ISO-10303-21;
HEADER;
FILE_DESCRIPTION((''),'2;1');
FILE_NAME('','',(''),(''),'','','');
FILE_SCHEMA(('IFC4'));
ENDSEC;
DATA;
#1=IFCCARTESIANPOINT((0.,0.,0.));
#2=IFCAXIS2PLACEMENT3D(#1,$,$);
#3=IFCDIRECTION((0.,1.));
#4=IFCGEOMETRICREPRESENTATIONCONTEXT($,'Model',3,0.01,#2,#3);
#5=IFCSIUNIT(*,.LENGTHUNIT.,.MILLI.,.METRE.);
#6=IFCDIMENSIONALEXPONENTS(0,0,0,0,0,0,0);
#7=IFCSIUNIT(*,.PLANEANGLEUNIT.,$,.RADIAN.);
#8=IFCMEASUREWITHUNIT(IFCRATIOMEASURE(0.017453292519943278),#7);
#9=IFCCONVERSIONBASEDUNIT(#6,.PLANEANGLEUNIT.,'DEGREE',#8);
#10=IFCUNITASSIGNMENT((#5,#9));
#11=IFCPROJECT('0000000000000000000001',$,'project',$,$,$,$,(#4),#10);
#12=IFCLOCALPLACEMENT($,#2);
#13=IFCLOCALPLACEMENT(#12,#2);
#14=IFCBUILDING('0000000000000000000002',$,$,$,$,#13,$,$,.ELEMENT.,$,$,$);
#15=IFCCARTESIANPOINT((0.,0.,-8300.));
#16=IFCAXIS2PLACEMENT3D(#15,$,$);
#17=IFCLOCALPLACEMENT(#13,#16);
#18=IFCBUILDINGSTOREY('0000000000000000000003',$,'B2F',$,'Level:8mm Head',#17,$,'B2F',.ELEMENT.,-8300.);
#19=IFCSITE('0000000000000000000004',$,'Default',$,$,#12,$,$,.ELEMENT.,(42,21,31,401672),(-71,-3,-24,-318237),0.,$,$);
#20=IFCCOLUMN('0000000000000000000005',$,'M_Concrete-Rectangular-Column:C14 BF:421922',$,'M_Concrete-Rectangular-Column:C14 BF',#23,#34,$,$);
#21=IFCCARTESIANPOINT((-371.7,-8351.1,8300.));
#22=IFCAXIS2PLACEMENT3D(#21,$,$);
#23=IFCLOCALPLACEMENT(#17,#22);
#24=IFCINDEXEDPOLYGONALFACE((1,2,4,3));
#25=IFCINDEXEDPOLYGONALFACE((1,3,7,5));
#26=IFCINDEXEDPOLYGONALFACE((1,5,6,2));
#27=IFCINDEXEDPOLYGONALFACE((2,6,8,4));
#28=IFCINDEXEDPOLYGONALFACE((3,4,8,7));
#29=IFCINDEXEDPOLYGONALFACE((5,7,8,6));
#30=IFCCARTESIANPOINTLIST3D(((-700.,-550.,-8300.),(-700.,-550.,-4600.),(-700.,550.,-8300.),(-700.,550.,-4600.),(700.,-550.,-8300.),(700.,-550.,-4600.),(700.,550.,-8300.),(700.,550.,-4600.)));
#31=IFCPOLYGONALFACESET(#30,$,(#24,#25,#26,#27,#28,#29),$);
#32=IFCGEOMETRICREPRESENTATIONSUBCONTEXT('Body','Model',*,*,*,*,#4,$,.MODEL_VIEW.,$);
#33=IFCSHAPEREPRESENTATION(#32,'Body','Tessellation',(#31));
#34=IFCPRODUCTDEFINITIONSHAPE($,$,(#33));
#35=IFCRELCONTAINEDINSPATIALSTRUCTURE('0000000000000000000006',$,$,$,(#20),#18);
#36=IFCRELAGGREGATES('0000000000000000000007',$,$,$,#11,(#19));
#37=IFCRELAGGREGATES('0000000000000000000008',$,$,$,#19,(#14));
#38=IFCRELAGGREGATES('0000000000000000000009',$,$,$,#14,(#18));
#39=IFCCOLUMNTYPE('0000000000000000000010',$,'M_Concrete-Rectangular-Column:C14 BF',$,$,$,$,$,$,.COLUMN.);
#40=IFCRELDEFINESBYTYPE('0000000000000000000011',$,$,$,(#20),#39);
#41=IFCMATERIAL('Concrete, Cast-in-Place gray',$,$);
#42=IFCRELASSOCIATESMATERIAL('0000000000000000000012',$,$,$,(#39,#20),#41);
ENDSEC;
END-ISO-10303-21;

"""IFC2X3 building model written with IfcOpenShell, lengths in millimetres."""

from ifc_helpers import new_model, entity, si_unit, converted_unit, direction, frame, origin, origin_2d_with_axis, place, context, subcontext, project, spatial, rectangle, extrude, source, transform, mapped, material, type_object, type_shapes, element, save


model = new_model("IFC2X3")

# Units and contexts
model_context = context("Model", 3, precision=0.01, world=origin(), true_north=direction((0.0, 1.0)))
body_context = subcontext(model_context, "Body", "Model", "MODEL_VIEW")
ifc_project = project(units=[si_unit("LENGTHUNIT", "METRE", prefix="MILLI"), converted_unit("PLANEANGLEUNIT", "DEGREE", entity("IfcRatioMeasure", 0.017453292519943278), si_unit("PLANEANGLEUNIT", "RADIAN"), dimensions=[0, 0, 0, 0, 0, 0, 0])], contexts=[model_context])

# Site, building, storey
site_placement = place(None, origin())
site = spatial("IfcSite", under=ifc_project, at=site_placement, Name="Default", CompositionType="ELEMENT", RefLatitude=(42, 21, 31, 401672), RefLongitude=(-71, -3, -24, -318237), RefElevation=0.0)
building_placement = place(site_placement, origin())
building = spatial("IfcBuilding", under=site, at=building_placement, CompositionType="ELEMENT")
storey_placement = place(building_placement, frame((0.0, 0.0, -8300.0)))
storey = spatial("IfcBuildingStorey", under=building, at=storey_placement, Name="B2F", ObjectType="Level:8mm Head", LongName="B2F", CompositionType="ELEMENT", Elevation=-8300.0)

# Column
ifc_material_1 = material(Name="Concrete, Cast-in-Place gray")
column_type = type_object("IfcColumnType", Name="M_Concrete-Rectangular-Column:C14 BF", PredefinedType="COLUMN", material=ifc_material_1)
shared_shape = source(origin(), body_context, "Body", "SweptSolid", [
    extrude(rectangle(XDim=1100.0, YDim=1400.0, at=origin_2d_with_axis()), frame((0.0, 0.0, -8300.0), z_axis=(0.0, 0.0, 1.0), x_axis=(0.0, -1.0, 0.0)), (0.0, 0.0, 1.0), 3700.0),
])
type_shapes(column_type, [shared_shape])
column_placement = place(storey_placement, frame((-371.7, -8351.1, 8300.0)))
element("IfcColumn", 1, at=column_placement, inside=storey, type_object=column_type, material=ifc_material_1, Name="M_Concrete-Rectangular-Column:C14 BF:421922", ObjectType="M_Concrete-Rectangular-Column:C14 BF", context=body_context, shape_type="MappedRepresentation", body=[
    mapped(shared_shape, transform((0.0, 0.0, 0.0), scale=1.0)),
])

save(model, "model.ifc")
